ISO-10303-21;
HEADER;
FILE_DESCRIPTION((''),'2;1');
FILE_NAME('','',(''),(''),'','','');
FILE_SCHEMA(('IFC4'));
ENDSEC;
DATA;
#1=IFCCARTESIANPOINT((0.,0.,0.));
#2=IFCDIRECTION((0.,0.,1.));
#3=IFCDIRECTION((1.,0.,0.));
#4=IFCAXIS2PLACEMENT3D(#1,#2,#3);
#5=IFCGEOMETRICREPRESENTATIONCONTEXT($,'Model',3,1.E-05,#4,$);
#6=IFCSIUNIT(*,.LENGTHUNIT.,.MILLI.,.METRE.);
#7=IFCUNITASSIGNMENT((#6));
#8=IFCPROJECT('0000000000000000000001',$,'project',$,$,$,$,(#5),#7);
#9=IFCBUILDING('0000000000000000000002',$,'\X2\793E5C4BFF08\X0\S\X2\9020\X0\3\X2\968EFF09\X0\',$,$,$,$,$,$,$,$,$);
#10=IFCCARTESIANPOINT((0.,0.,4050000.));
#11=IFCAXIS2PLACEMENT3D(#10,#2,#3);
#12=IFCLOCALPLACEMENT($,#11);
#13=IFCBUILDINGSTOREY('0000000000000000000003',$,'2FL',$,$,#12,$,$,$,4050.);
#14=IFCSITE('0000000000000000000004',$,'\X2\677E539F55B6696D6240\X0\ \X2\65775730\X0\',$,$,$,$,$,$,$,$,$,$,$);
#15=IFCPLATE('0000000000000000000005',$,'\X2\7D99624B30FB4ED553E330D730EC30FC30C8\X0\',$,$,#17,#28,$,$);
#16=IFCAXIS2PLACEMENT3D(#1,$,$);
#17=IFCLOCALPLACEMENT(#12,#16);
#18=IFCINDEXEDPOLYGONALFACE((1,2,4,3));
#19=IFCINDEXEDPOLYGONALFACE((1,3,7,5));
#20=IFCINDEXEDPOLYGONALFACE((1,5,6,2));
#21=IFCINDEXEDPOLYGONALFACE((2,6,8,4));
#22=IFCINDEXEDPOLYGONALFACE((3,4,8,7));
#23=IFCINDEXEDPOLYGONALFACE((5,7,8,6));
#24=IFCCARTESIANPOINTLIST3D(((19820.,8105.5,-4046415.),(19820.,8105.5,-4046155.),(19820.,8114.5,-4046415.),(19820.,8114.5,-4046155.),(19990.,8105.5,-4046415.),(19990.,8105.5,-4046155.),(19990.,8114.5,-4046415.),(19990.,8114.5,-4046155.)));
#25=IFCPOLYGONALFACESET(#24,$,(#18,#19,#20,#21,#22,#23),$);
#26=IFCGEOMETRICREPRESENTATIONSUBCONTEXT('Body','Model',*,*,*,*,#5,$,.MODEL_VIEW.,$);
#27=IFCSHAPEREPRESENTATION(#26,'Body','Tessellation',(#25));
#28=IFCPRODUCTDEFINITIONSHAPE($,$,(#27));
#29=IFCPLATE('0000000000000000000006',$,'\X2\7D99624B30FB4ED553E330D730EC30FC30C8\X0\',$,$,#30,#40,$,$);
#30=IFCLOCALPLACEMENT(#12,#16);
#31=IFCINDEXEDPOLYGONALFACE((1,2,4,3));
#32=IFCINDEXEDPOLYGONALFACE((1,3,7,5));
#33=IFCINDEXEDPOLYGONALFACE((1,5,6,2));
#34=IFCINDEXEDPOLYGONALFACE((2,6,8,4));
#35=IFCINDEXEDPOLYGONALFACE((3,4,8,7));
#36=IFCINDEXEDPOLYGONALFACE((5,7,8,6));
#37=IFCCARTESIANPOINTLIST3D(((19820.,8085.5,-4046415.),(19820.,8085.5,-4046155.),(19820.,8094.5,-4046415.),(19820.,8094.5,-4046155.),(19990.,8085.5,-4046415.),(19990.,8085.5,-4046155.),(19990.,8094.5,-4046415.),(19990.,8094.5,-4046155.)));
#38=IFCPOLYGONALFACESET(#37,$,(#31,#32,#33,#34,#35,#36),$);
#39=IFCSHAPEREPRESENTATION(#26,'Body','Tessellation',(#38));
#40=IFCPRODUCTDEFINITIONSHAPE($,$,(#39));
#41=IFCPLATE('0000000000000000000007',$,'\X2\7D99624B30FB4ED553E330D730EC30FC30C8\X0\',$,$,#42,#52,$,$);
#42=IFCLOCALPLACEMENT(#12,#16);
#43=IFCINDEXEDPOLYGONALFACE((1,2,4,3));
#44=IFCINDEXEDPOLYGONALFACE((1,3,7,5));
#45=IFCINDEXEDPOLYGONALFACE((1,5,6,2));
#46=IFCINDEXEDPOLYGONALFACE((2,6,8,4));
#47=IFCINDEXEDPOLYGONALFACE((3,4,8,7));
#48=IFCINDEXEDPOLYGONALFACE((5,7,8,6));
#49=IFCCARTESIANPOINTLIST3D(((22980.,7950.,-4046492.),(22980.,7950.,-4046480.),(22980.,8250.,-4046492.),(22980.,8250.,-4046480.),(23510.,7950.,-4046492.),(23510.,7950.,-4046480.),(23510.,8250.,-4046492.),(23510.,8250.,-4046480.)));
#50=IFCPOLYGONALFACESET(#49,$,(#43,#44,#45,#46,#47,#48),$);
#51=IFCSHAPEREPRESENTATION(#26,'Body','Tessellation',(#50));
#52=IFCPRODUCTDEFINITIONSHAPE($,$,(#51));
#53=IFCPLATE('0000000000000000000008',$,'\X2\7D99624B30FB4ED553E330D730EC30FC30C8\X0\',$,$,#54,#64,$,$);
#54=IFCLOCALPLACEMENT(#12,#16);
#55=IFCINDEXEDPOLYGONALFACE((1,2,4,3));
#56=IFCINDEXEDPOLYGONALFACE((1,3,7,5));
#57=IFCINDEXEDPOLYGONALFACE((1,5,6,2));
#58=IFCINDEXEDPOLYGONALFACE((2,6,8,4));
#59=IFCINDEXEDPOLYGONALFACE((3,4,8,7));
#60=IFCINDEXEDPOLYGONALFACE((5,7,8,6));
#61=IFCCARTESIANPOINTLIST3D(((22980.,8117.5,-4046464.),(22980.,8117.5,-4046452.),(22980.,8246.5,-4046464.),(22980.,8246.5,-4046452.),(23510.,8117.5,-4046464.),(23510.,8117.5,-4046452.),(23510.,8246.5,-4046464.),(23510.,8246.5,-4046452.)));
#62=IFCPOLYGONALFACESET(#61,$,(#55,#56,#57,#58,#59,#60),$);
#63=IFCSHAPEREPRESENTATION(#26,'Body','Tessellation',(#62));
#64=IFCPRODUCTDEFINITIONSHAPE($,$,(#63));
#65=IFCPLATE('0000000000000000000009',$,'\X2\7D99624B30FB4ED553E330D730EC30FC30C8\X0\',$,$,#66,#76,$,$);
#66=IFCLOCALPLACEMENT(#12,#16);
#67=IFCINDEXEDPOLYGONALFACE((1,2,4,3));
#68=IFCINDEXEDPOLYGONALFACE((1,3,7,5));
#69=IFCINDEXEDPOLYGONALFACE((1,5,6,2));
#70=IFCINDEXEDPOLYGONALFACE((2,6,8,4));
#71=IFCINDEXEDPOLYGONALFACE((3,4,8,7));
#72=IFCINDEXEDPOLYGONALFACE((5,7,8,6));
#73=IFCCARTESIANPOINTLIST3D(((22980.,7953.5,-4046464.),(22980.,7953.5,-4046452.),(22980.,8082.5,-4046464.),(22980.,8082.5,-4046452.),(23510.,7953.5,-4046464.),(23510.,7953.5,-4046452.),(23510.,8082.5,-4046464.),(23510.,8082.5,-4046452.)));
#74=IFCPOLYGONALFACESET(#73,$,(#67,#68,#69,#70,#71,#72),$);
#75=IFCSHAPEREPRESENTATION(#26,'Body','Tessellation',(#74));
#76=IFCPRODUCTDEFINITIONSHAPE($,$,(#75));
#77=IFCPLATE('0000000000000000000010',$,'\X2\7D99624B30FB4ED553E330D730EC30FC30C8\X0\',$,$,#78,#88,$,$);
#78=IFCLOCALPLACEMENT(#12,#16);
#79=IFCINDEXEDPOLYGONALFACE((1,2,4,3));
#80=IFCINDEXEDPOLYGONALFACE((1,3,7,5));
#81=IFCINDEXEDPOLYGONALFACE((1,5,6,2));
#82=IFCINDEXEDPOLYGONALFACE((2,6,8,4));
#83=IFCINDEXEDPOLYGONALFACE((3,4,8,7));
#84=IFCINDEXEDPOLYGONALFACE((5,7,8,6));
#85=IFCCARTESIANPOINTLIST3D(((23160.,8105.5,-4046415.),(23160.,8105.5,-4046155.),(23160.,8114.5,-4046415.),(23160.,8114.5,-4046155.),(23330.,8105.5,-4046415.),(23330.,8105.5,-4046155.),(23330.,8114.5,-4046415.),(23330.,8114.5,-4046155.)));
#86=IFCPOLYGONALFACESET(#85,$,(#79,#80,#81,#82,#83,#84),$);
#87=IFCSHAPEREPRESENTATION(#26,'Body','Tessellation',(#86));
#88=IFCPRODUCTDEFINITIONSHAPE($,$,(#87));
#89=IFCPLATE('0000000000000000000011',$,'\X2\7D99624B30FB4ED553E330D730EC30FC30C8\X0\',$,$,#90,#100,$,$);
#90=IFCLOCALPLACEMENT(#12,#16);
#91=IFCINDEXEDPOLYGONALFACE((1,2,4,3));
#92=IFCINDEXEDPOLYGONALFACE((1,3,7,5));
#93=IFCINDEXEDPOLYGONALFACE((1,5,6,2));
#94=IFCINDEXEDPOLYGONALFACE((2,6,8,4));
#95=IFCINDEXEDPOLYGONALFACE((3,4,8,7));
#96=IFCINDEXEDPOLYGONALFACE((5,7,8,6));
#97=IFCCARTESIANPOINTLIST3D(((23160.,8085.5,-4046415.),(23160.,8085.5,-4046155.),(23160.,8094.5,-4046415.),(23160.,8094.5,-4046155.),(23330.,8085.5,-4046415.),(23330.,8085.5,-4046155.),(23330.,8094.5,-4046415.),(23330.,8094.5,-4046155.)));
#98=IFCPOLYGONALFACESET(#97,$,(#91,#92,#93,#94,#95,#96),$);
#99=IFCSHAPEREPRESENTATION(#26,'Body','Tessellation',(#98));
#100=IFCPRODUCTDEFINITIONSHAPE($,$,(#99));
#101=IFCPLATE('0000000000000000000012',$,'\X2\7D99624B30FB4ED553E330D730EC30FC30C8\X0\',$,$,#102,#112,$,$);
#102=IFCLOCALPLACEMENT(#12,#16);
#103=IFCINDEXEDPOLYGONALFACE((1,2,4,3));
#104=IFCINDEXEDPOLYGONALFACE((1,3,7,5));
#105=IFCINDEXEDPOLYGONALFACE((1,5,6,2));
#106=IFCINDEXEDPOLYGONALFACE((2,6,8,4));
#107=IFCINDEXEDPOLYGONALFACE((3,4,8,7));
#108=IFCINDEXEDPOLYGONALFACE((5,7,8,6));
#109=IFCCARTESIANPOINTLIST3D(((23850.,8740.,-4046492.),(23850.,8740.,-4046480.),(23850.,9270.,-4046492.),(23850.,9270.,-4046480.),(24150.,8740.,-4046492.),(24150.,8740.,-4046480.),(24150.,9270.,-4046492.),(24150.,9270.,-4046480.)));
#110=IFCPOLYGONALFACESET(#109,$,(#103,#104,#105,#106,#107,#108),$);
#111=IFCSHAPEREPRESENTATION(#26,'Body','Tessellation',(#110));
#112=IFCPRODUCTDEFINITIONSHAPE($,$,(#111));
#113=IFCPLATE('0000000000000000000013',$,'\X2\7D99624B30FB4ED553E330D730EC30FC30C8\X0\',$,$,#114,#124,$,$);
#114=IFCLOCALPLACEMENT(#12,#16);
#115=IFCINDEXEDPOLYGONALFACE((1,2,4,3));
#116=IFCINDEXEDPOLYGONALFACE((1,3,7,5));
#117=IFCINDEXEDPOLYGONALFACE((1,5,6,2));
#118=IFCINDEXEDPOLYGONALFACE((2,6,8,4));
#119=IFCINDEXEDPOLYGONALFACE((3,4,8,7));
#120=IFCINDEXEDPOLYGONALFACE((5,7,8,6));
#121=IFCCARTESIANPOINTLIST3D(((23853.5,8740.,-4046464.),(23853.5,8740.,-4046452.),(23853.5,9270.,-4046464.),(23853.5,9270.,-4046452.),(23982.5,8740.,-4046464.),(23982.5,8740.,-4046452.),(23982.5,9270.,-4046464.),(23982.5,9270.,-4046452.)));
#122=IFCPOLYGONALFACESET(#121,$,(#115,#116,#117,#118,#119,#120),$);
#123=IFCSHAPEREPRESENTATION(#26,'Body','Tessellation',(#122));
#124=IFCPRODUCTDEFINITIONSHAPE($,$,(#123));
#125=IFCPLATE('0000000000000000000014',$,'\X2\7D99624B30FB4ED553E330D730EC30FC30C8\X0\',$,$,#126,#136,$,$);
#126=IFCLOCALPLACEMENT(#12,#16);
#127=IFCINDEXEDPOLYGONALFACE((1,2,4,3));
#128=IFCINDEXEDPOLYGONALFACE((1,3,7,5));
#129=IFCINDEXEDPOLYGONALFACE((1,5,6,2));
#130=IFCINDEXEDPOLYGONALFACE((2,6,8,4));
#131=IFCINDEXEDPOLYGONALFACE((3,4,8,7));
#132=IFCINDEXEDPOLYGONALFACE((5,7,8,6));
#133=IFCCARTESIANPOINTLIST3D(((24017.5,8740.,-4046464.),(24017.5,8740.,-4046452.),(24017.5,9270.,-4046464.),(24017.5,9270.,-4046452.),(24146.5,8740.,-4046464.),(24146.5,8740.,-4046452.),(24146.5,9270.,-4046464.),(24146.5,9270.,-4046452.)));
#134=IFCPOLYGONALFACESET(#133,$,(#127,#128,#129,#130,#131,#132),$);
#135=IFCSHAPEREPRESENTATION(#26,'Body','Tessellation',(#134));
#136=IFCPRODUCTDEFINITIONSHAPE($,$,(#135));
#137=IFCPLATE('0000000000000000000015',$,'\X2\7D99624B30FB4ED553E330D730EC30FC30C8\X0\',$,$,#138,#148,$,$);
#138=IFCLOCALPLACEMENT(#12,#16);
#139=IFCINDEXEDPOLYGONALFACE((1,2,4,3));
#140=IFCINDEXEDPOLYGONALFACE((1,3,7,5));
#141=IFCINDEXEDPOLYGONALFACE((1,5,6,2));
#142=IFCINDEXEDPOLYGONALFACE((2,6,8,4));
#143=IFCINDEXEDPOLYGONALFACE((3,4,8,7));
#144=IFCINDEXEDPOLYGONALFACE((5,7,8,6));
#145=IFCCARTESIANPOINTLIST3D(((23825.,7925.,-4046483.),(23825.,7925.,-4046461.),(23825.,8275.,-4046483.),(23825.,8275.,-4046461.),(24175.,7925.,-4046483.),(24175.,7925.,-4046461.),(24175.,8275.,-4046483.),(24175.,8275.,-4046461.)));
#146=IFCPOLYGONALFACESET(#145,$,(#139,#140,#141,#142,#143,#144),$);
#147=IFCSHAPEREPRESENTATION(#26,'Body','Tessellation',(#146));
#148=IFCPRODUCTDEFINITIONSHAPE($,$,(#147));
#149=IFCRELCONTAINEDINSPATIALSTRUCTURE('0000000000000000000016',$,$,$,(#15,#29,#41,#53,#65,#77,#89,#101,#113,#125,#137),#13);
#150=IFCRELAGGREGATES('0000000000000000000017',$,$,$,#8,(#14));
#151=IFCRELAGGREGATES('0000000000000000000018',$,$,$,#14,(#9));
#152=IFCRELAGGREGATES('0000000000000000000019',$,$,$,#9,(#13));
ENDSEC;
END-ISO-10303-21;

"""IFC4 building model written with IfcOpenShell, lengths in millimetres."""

from ifc_helpers import new_model, si_unit, frame, origin, origin_with_axes, place, context, subcontext, project, spatial, rectangle, extrude, element, save


model = new_model("IFC4")

# Units and contexts
model_context = context("Model", 3, precision=1e-05, world=origin_with_axes())
body_context = subcontext(model_context, "Body", "Model", "MODEL_VIEW")
ifc_project = project(units=[si_unit("LENGTHUNIT", "METRE", prefix="MILLI")], contexts=[model_context])

# Site, building, storey
site = spatial("IfcSite", under=ifc_project, Name="松原営業所 敷地")
building = spatial("IfcBuilding", under=site, Name="社屋（S造3階）")
storey_placement = place(None, frame((0.0, 0.0, 4050000.0), z_axis=(0.0, 0.0, 1.0), x_axis=(1.0, 0.0, 0.0)))
storey = spatial("IfcBuildingStorey", under=building, at=storey_placement, Name="2FL", Elevation=4050.0)

# Plates
for number, where, z_axis, x_axis, name in (
    (1, (19820.0, 8110.0, -4046285.0), (1.0, 0.0, 0.0), (0.0, 1.0, 0.0), "継手・仕口プレート"),
    (2, (19820.0, 8090.0, -4046285.0), (1.0, 0.0, 0.0), (0.0, 1.0, 0.0), "継手・仕口プレート"),
):
    element("IfcPlate", number, at=place(storey_placement, frame(where, z_axis=z_axis, x_axis=x_axis)), inside=storey, Name=name, context=body_context, shape_type="SweptSolid", body=[
        extrude(rectangle(XDim=9.0, YDim=260.0), origin(), (0.0, 0.0, 1.0), 170.0),
    ])
plate_1_placement = place(storey_placement, frame((22980.0, 8100.0, -4046486.0), z_axis=(1.0, 0.0, 0.0), x_axis=(0.0, 1.0, 0.0)))
element("IfcPlate", 3, at=plate_1_placement, inside=storey, Name="継手・仕口プレート", context=body_context, shape_type="SweptSolid", body=[
    extrude(rectangle(XDim=300.0, YDim=12.0), origin(), (0.0, 0.0, 1.0), 530.0),
])
for number, where, z_axis, x_axis, name in (
    (4, (22980.0, 8182.0, -4046458.0), (1.0, 0.0, 0.0), (0.0, 1.0, 0.0), "継手・仕口プレート"),
    (5, (22980.0, 8018.0, -4046458.0), (1.0, 0.0, 0.0), (0.0, 1.0, 0.0), "継手・仕口プレート"),
):
    element("IfcPlate", number, at=place(storey_placement, frame(where, z_axis=z_axis, x_axis=x_axis)), inside=storey, Name=name, context=body_context, shape_type="SweptSolid", body=[
        extrude(rectangle(XDim=129.0, YDim=12.0), origin(), (0.0, 0.0, 1.0), 530.0),
    ])
for number, where, z_axis, x_axis, name in (
    (6, (23160.0, 8110.0, -4046285.0), (1.0, 0.0, 0.0), (0.0, 1.0, 0.0), "継手・仕口プレート"),
    (7, (23160.0, 8090.0, -4046285.0), (1.0, 0.0, 0.0), (0.0, 1.0, 0.0), "継手・仕口プレート"),
):
    element("IfcPlate", number, at=place(storey_placement, frame(where, z_axis=z_axis, x_axis=x_axis)), inside=storey, Name=name, context=body_context, shape_type="SweptSolid", body=[
        extrude(rectangle(XDim=9.0, YDim=260.0), origin(), (0.0, 0.0, 1.0), 170.0),
    ])
plate_2_placement = place(storey_placement, frame((24000.0, 8740.0, -4046486.0), z_axis=(0.0, 1.0, 0.0), x_axis=(-1.0, 0.0, 0.0)))
element("IfcPlate", 8, at=plate_2_placement, inside=storey, Name="継手・仕口プレート", context=body_context, shape_type="SweptSolid", body=[
    extrude(rectangle(XDim=300.0, YDim=12.0), origin(), (0.0, 0.0, 1.0), 530.0),
])
for number, where, z_axis, x_axis, name in (
    (9, (23918.0, 8740.0, -4046458.0), (0.0, 1.0, 0.0), (-1.0, 0.0, 0.0), "継手・仕口プレート"),
    (10, (24082.0, 8740.0, -4046458.0), (0.0, 1.0, 0.0), (-1.0, 0.0, 0.0), "継手・仕口プレート"),
):
    element("IfcPlate", number, at=place(storey_placement, frame(where, z_axis=z_axis, x_axis=x_axis)), inside=storey, Name=name, context=body_context, shape_type="SweptSolid", body=[
        extrude(rectangle(XDim=129.0, YDim=12.0), origin(), (0.0, 0.0, 1.0), 530.0),
    ])
plate_3_placement = place(storey_placement, frame((23825.0, 8100.0, -4046472.0), z_axis=(1.0, 0.0, 0.0), x_axis=(0.0, 1.0, 0.0)))
element("IfcPlate", 11, at=plate_3_placement, inside=storey, Name="継手・仕口プレート", context=body_context, shape_type="SweptSolid", body=[
    extrude(rectangle(XDim=350.0, YDim=22.0), origin(), (0.0, 0.0, 1.0), 350.0),
])

save(model, "model.ifc")
